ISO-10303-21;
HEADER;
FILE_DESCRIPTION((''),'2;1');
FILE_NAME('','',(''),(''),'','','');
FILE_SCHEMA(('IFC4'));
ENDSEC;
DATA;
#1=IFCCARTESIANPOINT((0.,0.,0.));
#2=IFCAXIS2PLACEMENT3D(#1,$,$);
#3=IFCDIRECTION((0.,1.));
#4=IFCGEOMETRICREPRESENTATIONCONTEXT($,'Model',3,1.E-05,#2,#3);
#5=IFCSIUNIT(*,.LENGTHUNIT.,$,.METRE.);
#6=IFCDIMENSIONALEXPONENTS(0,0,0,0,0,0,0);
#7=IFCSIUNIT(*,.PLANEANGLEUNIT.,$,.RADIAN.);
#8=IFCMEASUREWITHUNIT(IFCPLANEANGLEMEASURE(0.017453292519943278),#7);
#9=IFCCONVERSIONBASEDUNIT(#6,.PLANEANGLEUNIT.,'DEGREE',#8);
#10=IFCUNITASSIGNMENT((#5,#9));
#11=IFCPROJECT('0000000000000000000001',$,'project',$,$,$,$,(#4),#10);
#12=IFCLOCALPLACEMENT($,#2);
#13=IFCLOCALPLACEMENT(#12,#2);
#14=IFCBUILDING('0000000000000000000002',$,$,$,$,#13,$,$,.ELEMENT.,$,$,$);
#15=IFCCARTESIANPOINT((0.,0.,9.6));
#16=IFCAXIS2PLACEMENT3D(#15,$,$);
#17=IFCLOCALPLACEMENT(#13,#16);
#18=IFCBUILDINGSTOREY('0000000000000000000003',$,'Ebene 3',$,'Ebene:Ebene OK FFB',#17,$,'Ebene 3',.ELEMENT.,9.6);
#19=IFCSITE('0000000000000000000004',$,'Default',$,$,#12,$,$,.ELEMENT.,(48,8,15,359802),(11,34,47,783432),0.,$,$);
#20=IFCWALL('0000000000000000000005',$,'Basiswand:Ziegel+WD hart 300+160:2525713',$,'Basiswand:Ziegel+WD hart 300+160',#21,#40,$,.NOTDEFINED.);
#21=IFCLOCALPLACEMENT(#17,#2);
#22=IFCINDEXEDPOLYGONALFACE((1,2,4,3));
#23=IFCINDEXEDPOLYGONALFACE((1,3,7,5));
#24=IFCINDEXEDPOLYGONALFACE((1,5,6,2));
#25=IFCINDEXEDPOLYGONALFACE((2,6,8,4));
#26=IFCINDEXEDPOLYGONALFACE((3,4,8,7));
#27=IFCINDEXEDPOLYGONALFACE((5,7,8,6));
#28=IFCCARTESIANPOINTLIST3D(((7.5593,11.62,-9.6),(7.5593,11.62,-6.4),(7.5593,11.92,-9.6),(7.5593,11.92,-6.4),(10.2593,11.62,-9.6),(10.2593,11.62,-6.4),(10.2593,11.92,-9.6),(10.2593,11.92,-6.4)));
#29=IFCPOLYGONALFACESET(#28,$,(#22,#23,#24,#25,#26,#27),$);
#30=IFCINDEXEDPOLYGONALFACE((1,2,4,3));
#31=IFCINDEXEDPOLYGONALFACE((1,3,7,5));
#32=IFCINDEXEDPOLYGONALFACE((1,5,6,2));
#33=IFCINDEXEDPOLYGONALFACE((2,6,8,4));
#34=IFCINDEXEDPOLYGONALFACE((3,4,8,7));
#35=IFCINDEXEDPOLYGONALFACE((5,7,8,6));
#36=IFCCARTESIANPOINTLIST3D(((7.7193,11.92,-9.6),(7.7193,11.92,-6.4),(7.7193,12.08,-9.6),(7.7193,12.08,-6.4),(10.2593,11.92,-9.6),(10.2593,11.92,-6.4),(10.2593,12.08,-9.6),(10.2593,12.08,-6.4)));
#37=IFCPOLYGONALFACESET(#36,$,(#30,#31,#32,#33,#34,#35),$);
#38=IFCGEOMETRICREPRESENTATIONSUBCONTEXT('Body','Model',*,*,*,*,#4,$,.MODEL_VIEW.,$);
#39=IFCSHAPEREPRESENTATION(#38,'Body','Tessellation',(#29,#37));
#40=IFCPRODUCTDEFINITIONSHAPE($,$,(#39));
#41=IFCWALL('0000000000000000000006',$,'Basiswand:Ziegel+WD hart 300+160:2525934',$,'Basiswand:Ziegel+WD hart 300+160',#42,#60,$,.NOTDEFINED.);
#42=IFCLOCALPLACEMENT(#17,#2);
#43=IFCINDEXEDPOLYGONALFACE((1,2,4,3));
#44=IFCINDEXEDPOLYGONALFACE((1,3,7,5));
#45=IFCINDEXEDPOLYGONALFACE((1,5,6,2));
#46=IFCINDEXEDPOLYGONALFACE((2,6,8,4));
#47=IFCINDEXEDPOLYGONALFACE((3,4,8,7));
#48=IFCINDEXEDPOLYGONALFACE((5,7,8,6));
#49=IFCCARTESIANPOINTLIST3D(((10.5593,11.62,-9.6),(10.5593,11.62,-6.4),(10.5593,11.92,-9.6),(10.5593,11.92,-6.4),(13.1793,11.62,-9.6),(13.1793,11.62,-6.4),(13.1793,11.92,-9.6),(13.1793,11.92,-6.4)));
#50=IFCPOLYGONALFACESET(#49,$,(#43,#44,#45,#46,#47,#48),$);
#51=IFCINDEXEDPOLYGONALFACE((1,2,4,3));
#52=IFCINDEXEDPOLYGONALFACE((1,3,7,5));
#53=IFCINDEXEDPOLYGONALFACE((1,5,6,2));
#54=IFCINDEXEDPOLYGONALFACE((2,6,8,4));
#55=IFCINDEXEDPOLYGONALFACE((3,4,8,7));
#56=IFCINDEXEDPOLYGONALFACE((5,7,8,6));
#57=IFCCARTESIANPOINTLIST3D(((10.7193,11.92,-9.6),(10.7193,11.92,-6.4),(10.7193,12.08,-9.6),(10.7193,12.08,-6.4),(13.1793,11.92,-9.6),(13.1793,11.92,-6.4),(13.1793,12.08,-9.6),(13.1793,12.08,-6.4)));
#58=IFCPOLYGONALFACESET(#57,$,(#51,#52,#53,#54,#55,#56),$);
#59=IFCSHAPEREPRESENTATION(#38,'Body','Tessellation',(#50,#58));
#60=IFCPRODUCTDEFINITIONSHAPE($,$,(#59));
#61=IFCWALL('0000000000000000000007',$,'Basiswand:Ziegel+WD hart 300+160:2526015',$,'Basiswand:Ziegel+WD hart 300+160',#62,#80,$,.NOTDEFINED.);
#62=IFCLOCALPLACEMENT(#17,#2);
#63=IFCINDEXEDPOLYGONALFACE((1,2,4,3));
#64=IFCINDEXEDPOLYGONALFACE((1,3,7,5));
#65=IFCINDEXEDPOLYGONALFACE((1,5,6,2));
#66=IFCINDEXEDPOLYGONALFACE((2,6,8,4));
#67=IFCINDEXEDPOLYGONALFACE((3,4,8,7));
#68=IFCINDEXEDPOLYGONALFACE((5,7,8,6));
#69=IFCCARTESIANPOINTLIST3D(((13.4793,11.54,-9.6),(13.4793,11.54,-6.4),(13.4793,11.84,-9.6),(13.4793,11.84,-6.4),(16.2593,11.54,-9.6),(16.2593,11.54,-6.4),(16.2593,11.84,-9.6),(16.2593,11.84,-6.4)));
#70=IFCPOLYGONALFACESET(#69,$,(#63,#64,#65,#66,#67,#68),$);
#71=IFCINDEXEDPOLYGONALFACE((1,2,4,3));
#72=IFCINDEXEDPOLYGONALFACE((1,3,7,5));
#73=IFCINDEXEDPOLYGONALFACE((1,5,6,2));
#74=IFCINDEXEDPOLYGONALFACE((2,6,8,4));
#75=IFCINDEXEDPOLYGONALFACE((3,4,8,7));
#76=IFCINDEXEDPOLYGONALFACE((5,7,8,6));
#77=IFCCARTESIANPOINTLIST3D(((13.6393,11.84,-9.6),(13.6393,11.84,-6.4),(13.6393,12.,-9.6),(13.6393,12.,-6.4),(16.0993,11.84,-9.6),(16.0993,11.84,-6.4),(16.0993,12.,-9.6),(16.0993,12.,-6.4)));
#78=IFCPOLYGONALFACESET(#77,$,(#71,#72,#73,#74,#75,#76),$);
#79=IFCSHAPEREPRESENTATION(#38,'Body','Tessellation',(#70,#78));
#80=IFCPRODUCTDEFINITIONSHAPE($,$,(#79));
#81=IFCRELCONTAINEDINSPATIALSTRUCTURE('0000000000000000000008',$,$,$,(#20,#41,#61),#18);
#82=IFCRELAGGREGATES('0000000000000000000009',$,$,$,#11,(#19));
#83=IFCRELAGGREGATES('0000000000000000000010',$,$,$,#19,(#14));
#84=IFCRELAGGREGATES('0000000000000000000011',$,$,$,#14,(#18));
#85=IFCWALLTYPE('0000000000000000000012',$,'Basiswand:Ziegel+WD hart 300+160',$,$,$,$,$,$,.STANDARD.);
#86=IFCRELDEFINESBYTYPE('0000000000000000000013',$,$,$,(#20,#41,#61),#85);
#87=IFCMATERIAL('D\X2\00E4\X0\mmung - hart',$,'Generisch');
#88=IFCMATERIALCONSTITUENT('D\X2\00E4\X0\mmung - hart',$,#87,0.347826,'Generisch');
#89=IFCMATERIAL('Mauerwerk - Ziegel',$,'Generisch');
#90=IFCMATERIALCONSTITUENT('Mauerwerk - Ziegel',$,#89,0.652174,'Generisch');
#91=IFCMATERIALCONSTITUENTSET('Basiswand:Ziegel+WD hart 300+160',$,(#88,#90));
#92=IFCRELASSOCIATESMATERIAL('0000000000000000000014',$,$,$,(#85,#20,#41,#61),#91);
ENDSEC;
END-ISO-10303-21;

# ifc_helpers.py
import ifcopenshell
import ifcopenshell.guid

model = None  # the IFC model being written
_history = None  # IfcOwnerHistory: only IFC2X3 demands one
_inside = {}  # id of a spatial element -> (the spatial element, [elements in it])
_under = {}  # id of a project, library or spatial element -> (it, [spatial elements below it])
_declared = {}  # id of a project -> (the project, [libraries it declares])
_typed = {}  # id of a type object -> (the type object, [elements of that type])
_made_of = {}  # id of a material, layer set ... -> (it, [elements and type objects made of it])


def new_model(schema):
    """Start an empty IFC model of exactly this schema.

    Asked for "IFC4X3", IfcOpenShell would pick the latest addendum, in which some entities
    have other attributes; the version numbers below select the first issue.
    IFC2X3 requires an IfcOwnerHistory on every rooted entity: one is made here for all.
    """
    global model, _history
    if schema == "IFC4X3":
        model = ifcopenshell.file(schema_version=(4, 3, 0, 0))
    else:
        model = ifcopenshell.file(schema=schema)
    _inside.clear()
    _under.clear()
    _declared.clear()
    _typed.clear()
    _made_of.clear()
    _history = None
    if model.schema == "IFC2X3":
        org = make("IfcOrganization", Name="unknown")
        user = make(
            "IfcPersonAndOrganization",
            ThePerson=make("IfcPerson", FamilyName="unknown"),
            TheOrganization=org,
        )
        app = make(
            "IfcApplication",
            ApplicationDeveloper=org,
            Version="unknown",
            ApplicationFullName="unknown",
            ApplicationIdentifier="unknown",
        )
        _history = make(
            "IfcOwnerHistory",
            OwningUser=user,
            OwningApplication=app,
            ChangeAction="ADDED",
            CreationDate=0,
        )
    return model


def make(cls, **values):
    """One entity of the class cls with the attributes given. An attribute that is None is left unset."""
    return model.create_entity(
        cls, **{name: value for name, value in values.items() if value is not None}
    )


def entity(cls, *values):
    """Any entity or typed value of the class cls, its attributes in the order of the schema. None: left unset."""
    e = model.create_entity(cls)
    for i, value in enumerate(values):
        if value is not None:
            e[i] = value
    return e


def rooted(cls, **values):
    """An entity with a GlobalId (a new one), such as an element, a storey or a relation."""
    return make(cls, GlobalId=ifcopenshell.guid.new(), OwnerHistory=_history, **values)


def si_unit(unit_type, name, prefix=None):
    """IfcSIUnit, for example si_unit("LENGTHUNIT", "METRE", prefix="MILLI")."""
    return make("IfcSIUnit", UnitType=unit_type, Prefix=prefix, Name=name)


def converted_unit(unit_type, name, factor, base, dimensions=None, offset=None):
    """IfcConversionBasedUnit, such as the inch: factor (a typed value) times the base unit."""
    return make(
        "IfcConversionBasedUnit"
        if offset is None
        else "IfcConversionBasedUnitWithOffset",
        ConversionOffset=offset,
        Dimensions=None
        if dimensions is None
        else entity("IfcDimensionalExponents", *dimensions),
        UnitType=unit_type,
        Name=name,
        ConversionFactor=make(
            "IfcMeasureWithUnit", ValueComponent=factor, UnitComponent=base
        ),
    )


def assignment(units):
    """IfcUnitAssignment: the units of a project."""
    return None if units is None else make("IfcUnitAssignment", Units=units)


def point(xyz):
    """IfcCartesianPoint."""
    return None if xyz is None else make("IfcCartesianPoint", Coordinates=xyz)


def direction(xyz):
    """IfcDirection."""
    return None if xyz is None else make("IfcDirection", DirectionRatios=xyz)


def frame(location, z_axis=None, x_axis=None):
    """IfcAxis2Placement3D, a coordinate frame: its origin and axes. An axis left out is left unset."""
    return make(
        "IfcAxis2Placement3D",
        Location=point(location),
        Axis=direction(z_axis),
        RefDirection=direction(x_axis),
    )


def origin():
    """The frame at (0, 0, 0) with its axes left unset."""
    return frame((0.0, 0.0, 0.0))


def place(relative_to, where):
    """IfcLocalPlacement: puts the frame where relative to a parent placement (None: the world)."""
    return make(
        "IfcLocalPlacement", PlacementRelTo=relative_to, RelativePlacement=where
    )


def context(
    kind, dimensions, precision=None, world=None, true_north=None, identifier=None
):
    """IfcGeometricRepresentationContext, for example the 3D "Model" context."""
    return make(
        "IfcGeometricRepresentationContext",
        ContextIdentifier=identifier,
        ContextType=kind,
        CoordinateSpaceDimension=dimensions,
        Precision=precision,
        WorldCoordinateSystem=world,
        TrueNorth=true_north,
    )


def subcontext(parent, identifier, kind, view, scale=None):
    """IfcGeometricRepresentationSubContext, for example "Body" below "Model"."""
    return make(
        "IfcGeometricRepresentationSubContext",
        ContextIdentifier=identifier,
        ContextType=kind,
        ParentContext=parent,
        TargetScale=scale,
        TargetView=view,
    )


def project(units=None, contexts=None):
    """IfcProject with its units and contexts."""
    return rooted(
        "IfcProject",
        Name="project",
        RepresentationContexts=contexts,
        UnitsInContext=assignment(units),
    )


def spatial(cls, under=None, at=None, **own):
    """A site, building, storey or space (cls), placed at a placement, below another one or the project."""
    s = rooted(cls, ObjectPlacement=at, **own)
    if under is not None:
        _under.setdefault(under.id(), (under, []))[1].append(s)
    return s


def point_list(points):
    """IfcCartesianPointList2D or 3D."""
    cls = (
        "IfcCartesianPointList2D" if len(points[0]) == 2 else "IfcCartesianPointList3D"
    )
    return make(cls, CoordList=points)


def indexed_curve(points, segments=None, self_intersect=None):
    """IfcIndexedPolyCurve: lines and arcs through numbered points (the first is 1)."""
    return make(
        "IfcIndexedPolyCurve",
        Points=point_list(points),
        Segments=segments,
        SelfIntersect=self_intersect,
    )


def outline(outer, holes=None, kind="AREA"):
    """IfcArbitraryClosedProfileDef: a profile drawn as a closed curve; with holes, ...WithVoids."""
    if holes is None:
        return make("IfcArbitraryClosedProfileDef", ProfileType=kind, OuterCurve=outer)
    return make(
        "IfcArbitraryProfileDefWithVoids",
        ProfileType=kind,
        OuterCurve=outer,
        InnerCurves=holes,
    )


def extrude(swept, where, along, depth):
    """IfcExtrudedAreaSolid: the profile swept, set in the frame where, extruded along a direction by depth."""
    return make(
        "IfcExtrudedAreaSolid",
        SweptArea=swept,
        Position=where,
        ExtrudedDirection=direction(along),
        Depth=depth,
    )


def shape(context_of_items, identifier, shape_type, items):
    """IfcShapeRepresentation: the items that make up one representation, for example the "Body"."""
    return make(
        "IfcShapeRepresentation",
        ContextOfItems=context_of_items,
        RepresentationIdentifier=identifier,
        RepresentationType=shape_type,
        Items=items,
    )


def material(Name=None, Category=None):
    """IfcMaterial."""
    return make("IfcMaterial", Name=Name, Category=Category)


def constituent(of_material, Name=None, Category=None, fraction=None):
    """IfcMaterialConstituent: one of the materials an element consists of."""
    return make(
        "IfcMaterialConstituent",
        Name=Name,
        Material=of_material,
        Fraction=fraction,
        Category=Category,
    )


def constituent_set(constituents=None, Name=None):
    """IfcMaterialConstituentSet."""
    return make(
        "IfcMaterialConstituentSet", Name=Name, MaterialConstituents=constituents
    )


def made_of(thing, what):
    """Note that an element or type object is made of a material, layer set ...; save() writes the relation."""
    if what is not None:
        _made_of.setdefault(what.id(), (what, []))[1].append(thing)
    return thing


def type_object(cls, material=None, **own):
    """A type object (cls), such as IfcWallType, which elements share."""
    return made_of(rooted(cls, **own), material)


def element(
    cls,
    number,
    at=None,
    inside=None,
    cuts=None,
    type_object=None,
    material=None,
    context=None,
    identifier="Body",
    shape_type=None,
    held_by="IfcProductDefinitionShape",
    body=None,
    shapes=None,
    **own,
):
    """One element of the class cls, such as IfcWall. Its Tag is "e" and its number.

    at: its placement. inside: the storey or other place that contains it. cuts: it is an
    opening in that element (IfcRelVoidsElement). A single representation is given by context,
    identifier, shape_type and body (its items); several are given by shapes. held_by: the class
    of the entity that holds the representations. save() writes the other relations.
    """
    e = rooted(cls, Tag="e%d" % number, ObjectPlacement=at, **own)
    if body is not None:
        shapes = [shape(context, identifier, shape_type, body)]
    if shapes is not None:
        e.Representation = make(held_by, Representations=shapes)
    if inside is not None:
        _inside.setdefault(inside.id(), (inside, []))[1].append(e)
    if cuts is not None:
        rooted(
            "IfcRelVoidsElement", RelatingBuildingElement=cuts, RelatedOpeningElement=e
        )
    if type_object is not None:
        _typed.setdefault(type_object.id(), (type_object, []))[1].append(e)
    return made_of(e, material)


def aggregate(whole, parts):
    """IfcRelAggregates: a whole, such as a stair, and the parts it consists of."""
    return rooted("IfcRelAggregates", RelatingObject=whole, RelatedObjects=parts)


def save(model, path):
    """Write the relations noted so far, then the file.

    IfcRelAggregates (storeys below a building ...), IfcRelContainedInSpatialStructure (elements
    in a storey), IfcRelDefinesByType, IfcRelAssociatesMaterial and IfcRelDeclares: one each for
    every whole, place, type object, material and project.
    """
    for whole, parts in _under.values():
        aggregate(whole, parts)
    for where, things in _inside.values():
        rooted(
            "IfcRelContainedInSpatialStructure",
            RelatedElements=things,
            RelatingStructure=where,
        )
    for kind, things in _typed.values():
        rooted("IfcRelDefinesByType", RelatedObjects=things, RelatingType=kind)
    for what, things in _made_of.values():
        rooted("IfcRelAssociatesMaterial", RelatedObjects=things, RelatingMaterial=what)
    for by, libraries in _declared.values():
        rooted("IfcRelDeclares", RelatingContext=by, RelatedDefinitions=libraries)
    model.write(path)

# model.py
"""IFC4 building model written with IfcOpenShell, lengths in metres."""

from ifc_helpers import new_model, entity, si_unit, converted_unit, direction, frame, origin, place, context, subcontext, project, spatial, indexed_curve, outline, extrude, material, constituent, constituent_set, type_object, element, save


model = new_model("IFC4")

# Units and contexts
model_context = context("Model", 3, precision=1e-05, world=origin(), true_north=direction((0.0, 1.0)))
body_context = subcontext(model_context, "Body", "Model", "MODEL_VIEW")
ifc_project = project(units=[si_unit("LENGTHUNIT", "METRE"), converted_unit("PLANEANGLEUNIT", "DEGREE", entity("IfcPlaneAngleMeasure", 0.017453292519943278), si_unit("PLANEANGLEUNIT", "RADIAN"), dimensions=[0, 0, 0, 0, 0, 0, 0])], contexts=[model_context])

# Site, building, storey
site_placement = place(None, origin())
site = spatial("IfcSite", under=ifc_project, at=site_placement, Name="Default", CompositionType="ELEMENT", RefLatitude=(48, 8, 15, 359802), RefLongitude=(11, 34, 47, 783432), RefElevation=0.0)
building_placement = place(site_placement, origin())
building = spatial("IfcBuilding", under=site, at=building_placement, CompositionType="ELEMENT")
storey_placement = place(building_placement, frame((0.0, 0.0, 9.6)))
storey = spatial("IfcBuildingStorey", under=building, at=storey_placement, Name="Ebene 3", ObjectType="Ebene:Ebene OK FFB", LongName="Ebene 3", CompositionType="ELEMENT", Elevation=9.6)

# Shared definitions
ifc_material_1 = material(Name="Dämmung - hart", Category="Generisch")
ifc_constituent_1 = constituent(ifc_material_1, Name="Dämmung - hart", Category="Generisch", fraction=0.347826)
ifc_material_2 = material(Name="Mauerwerk - Ziegel", Category="Generisch")
ifc_constituent_2 = constituent(ifc_material_2, Name="Mauerwerk - Ziegel", Category="Generisch", fraction=0.652174)
ifc_constituent_set = constituent_set(constituents=[ifc_constituent_1, ifc_constituent_2], Name="Basiswand:Ziegel+WD hart 300+160")
wall_type = type_object("IfcWallType", Name="Basiswand:Ziegel+WD hart 300+160", PredefinedType="STANDARD", material=ifc_constituent_set)

# Walls
wall_1_placement = place(storey_placement, frame((7.7193, 11.85, -9.6)))
element("IfcWall", 1, at=wall_1_placement, inside=storey, type_object=wall_type, material=ifc_constituent_set, Name="Basiswand:Ziegel+WD hart 300+160:2525713", ObjectType="Basiswand:Ziegel+WD hart 300+160", PredefinedType="NOTDEFINED", context=body_context, shape_type="SweptSolid", body=[
    extrude(outline(indexed_curve([(-0.15, -1.35), (0.15, -1.35), (0.15, 1.35), (-0.15, 1.35), (-0.15, -1.35)], self_intersect=False)), frame((1.19, -0.08, 0.0), z_axis=(0.0, 0.0, 1.0), x_axis=(0.0, 1.0, 0.0)), (0.0, 0.0, 1.0), 3.2),
    extrude(outline(indexed_curve([(-0.08, -1.27), (0.08, -1.27), (0.08, 1.27), (-0.08, 1.27), (-0.08, -1.27)], self_intersect=False)), frame((1.27, 0.15, 0.0), z_axis=(0.0, 0.0, 1.0), x_axis=(0.0, -1.0, 0.0)), (0.0, 0.0, 1.0), 3.2),
])
wall_2_placement = place(storey_placement, frame((10.7193, 11.85, -9.6)))
element("IfcWall", 2, at=wall_2_placement, inside=storey, type_object=wall_type, material=ifc_constituent_set, Name="Basiswand:Ziegel+WD hart 300+160:2525934", ObjectType="Basiswand:Ziegel+WD hart 300+160", PredefinedType="NOTDEFINED", context=body_context, shape_type="SweptSolid", body=[
    extrude(outline(indexed_curve([(-0.15, -1.31), (0.15, -1.31), (0.15, 1.31), (-0.15, 1.31), (-0.15, -1.31)], self_intersect=False)), frame((1.15, -0.08, 0.0), z_axis=(0.0, 0.0, 1.0), x_axis=(0.0, 1.0, 0.0)), (0.0, 0.0, 1.0), 3.2),
    extrude(outline(indexed_curve([(-0.08, -1.23), (0.08, -1.23), (0.08, 1.23), (-0.08, 1.23), (-0.08, -1.23)], self_intersect=False)), frame((1.23, 0.15, 0.0), z_axis=(0.0, 0.0, 1.0), x_axis=(0.0, -1.0, 0.0)), (0.0, 0.0, 1.0), 3.2),
])
wall_3_placement = place(storey_placement, frame((13.6393, 11.77, -9.6)))
element("IfcWall", 3, at=wall_3_placement, inside=storey, type_object=wall_type, material=ifc_constituent_set, Name="Basiswand:Ziegel+WD hart 300+160:2526015", ObjectType="Basiswand:Ziegel+WD hart 300+160", PredefinedType="NOTDEFINED", context=body_context, shape_type="SweptSolid", body=[
    extrude(outline(indexed_curve([(-0.15, -1.39), (0.15, -1.39), (0.15, 1.39), (-0.15, 1.39), (-0.15, -1.39)], self_intersect=False)), frame((1.23, -0.08, 0.0), z_axis=(0.0, 0.0, 1.0), x_axis=(0.0, 1.0, 0.0)), (0.0, 0.0, 1.0), 3.2),
    extrude(outline(indexed_curve([(-0.08, -1.23), (0.08, -1.23), (0.08, 1.23), (-0.08, 1.23), (-0.08, -1.23)], self_intersect=False)), frame((1.23, 0.15, 0.0), z_axis=(0.0, 0.0, 1.0), x_axis=(0.0, -1.0, 0.0)), (0.0, 0.0, 1.0), 3.2),
])

save(model, "model.ifc")
